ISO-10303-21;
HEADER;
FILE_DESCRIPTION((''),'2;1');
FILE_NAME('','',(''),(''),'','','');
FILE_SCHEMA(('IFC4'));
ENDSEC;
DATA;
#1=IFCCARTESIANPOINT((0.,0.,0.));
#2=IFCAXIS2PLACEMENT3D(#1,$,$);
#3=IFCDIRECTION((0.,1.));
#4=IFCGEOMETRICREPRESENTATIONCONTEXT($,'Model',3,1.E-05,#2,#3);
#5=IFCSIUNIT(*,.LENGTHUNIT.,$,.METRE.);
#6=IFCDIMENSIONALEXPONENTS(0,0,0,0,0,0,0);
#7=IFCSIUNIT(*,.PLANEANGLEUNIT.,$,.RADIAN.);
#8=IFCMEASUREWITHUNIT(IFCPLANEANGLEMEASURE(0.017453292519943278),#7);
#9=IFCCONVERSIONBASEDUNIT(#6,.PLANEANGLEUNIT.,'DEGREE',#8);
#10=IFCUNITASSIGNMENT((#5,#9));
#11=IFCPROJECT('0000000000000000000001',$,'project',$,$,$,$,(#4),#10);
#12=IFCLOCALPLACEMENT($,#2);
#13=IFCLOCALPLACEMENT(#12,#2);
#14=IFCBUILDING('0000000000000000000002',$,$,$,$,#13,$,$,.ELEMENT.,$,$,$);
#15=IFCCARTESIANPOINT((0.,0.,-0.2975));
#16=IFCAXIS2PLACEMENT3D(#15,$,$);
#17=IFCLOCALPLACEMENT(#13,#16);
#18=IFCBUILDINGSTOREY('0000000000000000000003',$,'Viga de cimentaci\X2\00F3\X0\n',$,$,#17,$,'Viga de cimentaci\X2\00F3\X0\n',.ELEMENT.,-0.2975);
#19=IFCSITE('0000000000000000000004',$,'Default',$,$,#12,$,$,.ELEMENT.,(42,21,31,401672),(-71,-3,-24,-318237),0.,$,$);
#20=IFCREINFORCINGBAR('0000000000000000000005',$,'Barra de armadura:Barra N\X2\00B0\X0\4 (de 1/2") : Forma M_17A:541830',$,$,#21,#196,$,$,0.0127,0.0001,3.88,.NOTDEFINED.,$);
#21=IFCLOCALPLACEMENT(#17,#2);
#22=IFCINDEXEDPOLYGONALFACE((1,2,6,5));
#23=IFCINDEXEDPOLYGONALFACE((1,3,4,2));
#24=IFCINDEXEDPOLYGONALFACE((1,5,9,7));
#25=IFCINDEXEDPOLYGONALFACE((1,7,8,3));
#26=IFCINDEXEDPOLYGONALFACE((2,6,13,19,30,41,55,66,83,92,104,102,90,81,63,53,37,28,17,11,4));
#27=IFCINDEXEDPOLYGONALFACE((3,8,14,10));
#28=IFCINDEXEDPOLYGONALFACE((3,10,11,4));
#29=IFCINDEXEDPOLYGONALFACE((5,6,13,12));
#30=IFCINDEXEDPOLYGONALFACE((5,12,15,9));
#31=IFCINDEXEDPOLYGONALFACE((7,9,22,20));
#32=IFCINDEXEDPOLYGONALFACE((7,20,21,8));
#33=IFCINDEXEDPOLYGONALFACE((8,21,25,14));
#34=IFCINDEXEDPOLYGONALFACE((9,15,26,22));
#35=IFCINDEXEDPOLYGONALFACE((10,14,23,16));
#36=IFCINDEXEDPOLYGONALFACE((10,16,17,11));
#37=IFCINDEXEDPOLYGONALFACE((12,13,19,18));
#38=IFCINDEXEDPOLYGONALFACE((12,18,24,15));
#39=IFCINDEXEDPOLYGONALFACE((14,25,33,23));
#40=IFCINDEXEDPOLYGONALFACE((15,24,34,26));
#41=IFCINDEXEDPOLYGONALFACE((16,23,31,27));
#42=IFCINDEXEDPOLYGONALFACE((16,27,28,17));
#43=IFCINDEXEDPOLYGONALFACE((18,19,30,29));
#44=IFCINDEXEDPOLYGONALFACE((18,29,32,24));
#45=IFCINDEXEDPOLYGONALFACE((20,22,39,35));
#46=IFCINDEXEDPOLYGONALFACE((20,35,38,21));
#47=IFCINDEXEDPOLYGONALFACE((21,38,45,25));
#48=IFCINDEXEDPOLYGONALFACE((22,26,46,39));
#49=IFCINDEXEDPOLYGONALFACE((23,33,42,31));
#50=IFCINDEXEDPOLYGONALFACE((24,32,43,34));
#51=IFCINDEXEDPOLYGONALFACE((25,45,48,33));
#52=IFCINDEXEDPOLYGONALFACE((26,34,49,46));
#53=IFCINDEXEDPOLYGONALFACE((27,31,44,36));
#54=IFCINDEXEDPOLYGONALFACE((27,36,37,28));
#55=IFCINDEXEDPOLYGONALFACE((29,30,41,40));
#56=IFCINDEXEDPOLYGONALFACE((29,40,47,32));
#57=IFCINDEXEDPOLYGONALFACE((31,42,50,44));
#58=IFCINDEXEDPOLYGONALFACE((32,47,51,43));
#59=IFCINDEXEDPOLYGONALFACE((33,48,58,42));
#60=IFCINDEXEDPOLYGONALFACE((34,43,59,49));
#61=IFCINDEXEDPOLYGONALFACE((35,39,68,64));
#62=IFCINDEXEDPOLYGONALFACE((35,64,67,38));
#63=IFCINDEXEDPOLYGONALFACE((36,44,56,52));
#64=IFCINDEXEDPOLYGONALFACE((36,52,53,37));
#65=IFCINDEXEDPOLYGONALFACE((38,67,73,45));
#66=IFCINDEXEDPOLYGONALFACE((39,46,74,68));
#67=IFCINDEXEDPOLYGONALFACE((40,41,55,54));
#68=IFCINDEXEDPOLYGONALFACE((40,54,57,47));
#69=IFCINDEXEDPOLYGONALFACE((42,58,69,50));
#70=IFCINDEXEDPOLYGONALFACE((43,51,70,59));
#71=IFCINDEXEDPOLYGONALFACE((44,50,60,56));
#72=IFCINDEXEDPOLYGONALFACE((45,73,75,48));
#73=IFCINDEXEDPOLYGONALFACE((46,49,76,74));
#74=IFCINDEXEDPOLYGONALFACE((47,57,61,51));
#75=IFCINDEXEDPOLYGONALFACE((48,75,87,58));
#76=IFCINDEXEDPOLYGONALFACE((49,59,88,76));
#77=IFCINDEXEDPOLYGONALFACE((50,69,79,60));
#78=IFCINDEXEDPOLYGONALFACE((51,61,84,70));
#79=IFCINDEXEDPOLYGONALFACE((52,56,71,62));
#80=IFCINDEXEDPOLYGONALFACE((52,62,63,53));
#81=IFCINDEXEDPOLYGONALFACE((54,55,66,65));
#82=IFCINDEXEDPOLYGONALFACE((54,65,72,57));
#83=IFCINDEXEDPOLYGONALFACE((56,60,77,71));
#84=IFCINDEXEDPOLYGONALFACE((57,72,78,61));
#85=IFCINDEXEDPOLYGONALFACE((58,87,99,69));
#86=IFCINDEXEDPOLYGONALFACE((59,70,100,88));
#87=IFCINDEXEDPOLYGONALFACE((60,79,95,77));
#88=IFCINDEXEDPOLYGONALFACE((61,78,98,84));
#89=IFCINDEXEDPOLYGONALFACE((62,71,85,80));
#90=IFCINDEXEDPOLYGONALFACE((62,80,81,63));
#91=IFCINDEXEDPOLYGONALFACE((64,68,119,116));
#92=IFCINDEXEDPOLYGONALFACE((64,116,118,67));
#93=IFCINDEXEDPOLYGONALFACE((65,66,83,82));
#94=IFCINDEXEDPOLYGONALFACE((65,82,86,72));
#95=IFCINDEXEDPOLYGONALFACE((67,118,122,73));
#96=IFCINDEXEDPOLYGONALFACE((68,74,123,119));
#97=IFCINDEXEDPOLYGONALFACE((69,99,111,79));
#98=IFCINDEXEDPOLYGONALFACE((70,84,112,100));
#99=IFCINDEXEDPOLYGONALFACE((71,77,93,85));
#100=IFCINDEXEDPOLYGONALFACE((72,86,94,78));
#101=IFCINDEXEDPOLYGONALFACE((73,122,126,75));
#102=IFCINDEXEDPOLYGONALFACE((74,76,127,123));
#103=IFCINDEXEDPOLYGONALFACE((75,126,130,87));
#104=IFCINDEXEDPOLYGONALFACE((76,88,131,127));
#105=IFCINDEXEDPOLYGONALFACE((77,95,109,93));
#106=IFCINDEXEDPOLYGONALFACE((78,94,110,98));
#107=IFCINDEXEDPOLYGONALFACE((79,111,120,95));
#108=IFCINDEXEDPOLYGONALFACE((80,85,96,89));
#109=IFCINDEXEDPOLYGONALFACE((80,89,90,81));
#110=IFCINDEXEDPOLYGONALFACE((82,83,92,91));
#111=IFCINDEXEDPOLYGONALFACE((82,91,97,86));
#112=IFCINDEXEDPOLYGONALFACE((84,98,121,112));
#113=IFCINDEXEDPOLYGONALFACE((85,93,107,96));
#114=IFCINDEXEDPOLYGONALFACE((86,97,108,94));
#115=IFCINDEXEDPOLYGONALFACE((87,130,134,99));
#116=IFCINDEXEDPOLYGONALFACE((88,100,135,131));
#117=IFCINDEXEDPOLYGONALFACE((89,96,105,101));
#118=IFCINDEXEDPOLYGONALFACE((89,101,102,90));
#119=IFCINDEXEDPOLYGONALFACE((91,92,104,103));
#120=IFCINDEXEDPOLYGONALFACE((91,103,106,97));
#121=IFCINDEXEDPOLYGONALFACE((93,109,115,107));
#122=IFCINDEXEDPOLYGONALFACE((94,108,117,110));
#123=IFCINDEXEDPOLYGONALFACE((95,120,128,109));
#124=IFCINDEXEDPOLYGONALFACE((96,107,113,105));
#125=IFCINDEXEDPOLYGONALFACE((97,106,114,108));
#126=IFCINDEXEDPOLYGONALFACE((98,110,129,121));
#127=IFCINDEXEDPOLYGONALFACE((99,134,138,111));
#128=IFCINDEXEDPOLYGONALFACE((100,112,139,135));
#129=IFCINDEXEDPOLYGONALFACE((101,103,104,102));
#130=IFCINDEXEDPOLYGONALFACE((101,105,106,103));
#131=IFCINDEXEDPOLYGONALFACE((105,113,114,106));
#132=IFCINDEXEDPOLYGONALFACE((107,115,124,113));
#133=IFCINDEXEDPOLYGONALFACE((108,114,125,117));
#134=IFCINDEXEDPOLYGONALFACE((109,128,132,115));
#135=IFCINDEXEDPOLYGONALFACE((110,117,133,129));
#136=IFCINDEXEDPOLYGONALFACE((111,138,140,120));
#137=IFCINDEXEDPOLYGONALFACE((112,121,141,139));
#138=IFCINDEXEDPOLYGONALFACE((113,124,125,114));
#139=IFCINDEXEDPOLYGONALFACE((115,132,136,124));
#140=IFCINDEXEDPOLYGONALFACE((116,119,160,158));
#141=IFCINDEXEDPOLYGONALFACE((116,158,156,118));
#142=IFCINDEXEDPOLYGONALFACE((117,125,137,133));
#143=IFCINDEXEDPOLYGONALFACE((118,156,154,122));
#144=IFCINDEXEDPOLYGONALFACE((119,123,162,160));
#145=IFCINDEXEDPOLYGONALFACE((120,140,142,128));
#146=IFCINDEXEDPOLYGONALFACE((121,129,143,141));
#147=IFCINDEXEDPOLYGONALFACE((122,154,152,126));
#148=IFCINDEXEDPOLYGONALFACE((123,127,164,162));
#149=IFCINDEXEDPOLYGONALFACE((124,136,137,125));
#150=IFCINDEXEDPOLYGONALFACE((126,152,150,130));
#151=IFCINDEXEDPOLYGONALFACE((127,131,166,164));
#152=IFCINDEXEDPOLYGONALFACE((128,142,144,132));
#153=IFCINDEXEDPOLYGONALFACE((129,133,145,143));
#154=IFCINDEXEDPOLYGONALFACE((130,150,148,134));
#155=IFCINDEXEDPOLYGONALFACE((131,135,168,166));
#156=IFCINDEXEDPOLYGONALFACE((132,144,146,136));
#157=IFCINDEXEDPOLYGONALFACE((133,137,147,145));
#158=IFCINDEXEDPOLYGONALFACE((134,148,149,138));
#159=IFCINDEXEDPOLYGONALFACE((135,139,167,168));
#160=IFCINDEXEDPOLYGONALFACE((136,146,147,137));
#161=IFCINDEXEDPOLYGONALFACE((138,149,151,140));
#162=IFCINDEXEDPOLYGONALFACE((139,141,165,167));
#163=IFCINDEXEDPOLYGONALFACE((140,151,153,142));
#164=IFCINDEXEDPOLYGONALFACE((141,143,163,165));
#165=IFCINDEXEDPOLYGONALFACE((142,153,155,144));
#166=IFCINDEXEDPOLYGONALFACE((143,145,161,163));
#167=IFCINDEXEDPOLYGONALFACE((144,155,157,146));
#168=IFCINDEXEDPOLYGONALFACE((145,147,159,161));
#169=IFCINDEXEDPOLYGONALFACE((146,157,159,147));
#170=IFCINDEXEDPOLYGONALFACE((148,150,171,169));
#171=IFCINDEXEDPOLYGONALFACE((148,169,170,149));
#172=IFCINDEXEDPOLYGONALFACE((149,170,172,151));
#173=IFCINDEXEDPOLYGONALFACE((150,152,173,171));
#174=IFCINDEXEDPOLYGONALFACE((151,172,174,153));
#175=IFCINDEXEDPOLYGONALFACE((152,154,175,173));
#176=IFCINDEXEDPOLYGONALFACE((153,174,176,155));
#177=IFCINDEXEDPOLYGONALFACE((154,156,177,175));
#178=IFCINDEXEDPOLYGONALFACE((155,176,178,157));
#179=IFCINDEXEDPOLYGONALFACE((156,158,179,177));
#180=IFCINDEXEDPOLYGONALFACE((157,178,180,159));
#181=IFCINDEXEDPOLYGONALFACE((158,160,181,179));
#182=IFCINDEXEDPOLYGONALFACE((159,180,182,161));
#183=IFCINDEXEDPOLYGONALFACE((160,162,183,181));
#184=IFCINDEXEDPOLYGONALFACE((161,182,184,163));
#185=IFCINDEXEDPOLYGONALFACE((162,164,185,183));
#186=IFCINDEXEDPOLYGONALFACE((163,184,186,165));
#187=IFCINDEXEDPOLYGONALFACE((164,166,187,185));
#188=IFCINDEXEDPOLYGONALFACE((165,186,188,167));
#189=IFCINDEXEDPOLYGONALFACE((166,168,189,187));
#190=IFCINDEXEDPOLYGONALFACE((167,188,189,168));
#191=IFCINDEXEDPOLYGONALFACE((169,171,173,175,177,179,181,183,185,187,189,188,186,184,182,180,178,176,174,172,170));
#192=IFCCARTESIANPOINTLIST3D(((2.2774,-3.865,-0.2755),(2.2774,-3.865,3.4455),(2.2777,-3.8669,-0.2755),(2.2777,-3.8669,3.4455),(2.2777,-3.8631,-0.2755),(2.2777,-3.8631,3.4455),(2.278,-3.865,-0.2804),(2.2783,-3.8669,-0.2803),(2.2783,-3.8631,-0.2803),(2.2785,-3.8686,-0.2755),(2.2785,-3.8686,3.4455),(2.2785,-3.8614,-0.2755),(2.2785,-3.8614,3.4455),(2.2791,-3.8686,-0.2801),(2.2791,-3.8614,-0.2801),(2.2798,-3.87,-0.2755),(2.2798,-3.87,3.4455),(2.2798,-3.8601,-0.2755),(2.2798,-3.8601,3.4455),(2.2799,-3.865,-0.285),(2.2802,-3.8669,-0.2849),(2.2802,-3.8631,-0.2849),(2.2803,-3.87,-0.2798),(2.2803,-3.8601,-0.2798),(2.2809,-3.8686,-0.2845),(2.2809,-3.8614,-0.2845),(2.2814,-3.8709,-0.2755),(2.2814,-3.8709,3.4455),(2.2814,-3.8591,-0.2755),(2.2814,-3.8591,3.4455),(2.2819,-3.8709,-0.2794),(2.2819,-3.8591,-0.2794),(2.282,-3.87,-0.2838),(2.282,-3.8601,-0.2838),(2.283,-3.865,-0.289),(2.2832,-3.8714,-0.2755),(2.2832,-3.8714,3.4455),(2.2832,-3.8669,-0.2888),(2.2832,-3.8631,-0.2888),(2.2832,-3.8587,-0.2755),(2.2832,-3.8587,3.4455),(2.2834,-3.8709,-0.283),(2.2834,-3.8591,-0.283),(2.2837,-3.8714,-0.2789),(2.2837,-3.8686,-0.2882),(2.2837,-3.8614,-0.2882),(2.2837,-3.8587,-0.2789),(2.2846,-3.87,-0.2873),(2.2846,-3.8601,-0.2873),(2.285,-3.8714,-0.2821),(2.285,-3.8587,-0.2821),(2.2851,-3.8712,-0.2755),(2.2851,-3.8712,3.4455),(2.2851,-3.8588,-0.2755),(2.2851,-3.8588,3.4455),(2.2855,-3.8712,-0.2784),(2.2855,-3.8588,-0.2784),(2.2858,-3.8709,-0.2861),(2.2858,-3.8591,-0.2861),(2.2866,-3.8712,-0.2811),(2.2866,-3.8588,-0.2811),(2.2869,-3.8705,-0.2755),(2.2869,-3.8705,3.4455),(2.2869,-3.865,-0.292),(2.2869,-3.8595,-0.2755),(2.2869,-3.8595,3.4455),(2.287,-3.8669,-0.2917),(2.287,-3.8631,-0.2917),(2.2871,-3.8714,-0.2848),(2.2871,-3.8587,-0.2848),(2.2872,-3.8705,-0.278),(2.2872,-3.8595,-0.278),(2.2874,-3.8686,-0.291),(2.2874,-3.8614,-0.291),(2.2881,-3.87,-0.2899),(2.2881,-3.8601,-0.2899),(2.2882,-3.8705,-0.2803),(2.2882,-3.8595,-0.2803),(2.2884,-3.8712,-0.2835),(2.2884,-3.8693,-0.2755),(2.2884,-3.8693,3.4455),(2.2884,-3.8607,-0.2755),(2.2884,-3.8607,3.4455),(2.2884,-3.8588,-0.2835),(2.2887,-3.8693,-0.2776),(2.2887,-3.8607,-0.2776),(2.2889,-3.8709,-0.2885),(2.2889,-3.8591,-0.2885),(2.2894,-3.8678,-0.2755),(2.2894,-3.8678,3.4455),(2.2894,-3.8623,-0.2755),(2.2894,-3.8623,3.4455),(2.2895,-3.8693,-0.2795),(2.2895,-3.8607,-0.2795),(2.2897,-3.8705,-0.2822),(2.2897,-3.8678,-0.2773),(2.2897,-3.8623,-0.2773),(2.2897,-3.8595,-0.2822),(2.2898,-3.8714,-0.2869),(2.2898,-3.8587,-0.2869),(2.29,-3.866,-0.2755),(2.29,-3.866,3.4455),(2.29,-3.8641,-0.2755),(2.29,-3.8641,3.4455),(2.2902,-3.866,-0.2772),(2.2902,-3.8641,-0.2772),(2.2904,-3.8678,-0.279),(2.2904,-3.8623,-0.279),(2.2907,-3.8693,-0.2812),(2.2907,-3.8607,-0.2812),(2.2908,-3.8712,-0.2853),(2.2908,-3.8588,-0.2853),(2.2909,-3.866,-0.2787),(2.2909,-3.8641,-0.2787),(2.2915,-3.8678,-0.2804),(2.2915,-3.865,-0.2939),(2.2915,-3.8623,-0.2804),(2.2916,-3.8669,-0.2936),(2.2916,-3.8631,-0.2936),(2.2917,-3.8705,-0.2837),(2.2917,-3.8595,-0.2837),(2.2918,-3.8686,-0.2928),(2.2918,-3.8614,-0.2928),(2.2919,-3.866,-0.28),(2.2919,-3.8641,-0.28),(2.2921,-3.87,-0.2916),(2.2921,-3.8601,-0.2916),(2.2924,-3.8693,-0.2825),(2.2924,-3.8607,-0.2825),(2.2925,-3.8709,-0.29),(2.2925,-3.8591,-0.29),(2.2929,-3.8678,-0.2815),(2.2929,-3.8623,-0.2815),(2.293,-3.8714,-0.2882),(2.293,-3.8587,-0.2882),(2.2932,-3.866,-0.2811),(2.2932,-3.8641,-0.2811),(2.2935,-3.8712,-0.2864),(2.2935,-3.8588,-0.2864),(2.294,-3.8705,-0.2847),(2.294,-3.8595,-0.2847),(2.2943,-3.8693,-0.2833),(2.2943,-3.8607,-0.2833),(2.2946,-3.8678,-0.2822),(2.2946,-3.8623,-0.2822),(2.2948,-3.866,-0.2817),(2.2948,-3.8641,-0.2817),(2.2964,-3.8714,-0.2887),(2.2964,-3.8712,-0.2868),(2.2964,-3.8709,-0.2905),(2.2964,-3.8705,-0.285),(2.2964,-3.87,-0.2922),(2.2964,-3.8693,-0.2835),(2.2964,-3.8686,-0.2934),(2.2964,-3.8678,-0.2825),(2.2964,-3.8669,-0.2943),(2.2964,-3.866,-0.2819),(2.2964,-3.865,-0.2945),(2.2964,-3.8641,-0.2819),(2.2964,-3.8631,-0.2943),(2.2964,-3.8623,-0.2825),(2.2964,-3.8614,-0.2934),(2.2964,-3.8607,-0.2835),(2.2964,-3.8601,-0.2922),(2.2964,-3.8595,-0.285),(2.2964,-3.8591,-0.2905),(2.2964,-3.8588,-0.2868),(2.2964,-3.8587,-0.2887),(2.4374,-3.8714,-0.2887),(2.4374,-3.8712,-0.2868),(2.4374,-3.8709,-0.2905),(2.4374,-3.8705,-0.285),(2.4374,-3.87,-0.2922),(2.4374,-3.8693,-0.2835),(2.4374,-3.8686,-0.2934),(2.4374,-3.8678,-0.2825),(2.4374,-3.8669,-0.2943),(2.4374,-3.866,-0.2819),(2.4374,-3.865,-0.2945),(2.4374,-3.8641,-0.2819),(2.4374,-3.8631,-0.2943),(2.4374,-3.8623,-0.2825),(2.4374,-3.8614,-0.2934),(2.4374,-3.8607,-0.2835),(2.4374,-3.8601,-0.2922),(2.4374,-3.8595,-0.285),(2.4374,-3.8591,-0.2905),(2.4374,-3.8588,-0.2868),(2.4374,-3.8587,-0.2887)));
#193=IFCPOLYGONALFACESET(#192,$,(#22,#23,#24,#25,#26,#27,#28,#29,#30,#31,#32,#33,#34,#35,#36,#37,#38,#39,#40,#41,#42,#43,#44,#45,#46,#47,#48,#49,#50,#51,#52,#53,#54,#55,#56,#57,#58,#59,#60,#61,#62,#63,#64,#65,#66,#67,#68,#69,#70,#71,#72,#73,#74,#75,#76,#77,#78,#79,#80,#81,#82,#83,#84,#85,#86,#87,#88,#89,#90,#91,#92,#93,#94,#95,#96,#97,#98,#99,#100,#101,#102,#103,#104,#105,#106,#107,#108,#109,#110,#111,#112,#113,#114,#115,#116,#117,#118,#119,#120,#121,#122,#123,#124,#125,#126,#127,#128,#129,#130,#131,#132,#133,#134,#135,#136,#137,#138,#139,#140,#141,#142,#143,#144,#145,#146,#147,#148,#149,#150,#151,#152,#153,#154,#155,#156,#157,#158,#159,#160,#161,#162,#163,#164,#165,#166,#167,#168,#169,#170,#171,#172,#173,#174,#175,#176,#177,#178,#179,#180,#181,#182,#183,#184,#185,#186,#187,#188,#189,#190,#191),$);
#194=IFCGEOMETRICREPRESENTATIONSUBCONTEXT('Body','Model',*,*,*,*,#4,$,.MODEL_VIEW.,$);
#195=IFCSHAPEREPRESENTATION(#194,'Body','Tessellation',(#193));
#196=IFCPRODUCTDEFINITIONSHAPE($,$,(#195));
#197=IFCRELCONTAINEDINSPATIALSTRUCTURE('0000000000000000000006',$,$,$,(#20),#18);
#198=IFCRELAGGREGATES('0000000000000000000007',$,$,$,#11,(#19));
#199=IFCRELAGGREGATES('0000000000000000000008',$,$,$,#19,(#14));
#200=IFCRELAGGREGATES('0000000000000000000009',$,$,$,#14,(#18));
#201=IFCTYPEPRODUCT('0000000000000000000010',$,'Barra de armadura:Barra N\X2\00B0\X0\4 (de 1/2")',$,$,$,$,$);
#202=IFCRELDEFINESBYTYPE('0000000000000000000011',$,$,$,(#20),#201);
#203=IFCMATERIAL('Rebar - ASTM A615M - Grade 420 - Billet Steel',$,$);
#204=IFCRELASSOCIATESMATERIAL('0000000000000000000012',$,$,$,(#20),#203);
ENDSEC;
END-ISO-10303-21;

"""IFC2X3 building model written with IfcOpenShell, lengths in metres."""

from ifc_helpers import new_model, entity, si_unit, converted_unit, direction, frame, origin, place, context, subcontext, project, spatial, material, type_object, element, save


model = new_model("IFC2X3")

# Units and contexts
model_context = context("Model", 3, precision=1e-05, world=origin(), true_north=direction((0.0, 1.0)))
body_context = subcontext(model_context, "Body", "Model", "MODEL_VIEW")
ifc_project = project(units=[si_unit("LENGTHUNIT", "METRE"), converted_unit("PLANEANGLEUNIT", "DEGREE", entity("IfcPlaneAngleMeasure", 0.017453292519943278), si_unit("PLANEANGLEUNIT", "RADIAN"), dimensions=[0, 0, 0, 0, 0, 0, 0])], contexts=[model_context])

# Site, building, storey
site_placement = place(None, origin())
site = spatial("IfcSite", under=ifc_project, at=site_placement, Name="Default", CompositionType="ELEMENT", RefLatitude=(42, 21, 31, 401672), RefLongitude=(-71, -3, -24, -318237), RefElevation=0.0)
building_placement = place(site_placement, origin())
building = spatial("IfcBuilding", under=site, at=building_placement, CompositionType="ELEMENT")
storey_placement = place(building_placement, frame((0.0, 0.0, -0.2975)))
storey = spatial("IfcBuildingStorey", under=building, at=storey_placement, Name="Viga de cimentación", LongName="Viga de cimentación", CompositionType="ELEMENT", Elevation=-0.2975)

# Reinforcing bar
ifc_material_1 = material(Name="Rebar - ASTM A615M - Grade 420 - Billet Steel")
type_product_1 = type_object("IfcTypeProduct", Name="Barra de armadura:Barra N°4 (de 1/2\")")
reinforcing_bar_1_placement = place(storey_placement, origin())
element("IfcReinforcingBar", 1, at=reinforcing_bar_1_placement, inside=storey, type_object=type_product_1, material=ifc_material_1, Name="Barra de armadura:Barra N°4 (de 1/2\") : Forma M_17A:541830", BarLength=3.88, BarRole="NOTDEFINED", CrossSectionArea=0.0001, NominalDiameter=0.0127, context=body_context, shape_type="AdvancedSweptSolid", body=[
    entity("IfcSweptDiskSolid", entity("IfcCompositeCurve", [entity("IfcCompositeCurveSegment", "CONTINUOUS", True, entity("IfcPolyline", [entity("IfcCartesianPoint", [2.2837, -3.865, 3.4455]), entity("IfcCartesianPoint", [2.2837, -3.865, -0.2755])])), entity("IfcCompositeCurveSegment", "CONTINUOUS", True, entity("IfcTrimmedCurve", entity("IfcCircle", entity("IfcAxis2Placement3D", entity("IfcCartesianPoint", [2.2964, -3.865, -0.2755]), entity("IfcDirection", [0.0, -1.0, 0.0]), entity("IfcDirection", [0.0, 0.0, -1.0])), 0.0127), [entity("IfcParameterValue", 270.0)], [entity("IfcParameterValue", 360.0)], True, "PARAMETER")), entity("IfcCompositeCurveSegment", "CONTINUOUS", True, entity("IfcPolyline", [entity("IfcCartesianPoint", [2.2964, -3.865, -0.2882]), entity("IfcCartesianPoint", [2.4374, -3.865, -0.2882])]))], False), 0.0063, None, 0.0, 92.0),
])

save(model, "model.ifc")
